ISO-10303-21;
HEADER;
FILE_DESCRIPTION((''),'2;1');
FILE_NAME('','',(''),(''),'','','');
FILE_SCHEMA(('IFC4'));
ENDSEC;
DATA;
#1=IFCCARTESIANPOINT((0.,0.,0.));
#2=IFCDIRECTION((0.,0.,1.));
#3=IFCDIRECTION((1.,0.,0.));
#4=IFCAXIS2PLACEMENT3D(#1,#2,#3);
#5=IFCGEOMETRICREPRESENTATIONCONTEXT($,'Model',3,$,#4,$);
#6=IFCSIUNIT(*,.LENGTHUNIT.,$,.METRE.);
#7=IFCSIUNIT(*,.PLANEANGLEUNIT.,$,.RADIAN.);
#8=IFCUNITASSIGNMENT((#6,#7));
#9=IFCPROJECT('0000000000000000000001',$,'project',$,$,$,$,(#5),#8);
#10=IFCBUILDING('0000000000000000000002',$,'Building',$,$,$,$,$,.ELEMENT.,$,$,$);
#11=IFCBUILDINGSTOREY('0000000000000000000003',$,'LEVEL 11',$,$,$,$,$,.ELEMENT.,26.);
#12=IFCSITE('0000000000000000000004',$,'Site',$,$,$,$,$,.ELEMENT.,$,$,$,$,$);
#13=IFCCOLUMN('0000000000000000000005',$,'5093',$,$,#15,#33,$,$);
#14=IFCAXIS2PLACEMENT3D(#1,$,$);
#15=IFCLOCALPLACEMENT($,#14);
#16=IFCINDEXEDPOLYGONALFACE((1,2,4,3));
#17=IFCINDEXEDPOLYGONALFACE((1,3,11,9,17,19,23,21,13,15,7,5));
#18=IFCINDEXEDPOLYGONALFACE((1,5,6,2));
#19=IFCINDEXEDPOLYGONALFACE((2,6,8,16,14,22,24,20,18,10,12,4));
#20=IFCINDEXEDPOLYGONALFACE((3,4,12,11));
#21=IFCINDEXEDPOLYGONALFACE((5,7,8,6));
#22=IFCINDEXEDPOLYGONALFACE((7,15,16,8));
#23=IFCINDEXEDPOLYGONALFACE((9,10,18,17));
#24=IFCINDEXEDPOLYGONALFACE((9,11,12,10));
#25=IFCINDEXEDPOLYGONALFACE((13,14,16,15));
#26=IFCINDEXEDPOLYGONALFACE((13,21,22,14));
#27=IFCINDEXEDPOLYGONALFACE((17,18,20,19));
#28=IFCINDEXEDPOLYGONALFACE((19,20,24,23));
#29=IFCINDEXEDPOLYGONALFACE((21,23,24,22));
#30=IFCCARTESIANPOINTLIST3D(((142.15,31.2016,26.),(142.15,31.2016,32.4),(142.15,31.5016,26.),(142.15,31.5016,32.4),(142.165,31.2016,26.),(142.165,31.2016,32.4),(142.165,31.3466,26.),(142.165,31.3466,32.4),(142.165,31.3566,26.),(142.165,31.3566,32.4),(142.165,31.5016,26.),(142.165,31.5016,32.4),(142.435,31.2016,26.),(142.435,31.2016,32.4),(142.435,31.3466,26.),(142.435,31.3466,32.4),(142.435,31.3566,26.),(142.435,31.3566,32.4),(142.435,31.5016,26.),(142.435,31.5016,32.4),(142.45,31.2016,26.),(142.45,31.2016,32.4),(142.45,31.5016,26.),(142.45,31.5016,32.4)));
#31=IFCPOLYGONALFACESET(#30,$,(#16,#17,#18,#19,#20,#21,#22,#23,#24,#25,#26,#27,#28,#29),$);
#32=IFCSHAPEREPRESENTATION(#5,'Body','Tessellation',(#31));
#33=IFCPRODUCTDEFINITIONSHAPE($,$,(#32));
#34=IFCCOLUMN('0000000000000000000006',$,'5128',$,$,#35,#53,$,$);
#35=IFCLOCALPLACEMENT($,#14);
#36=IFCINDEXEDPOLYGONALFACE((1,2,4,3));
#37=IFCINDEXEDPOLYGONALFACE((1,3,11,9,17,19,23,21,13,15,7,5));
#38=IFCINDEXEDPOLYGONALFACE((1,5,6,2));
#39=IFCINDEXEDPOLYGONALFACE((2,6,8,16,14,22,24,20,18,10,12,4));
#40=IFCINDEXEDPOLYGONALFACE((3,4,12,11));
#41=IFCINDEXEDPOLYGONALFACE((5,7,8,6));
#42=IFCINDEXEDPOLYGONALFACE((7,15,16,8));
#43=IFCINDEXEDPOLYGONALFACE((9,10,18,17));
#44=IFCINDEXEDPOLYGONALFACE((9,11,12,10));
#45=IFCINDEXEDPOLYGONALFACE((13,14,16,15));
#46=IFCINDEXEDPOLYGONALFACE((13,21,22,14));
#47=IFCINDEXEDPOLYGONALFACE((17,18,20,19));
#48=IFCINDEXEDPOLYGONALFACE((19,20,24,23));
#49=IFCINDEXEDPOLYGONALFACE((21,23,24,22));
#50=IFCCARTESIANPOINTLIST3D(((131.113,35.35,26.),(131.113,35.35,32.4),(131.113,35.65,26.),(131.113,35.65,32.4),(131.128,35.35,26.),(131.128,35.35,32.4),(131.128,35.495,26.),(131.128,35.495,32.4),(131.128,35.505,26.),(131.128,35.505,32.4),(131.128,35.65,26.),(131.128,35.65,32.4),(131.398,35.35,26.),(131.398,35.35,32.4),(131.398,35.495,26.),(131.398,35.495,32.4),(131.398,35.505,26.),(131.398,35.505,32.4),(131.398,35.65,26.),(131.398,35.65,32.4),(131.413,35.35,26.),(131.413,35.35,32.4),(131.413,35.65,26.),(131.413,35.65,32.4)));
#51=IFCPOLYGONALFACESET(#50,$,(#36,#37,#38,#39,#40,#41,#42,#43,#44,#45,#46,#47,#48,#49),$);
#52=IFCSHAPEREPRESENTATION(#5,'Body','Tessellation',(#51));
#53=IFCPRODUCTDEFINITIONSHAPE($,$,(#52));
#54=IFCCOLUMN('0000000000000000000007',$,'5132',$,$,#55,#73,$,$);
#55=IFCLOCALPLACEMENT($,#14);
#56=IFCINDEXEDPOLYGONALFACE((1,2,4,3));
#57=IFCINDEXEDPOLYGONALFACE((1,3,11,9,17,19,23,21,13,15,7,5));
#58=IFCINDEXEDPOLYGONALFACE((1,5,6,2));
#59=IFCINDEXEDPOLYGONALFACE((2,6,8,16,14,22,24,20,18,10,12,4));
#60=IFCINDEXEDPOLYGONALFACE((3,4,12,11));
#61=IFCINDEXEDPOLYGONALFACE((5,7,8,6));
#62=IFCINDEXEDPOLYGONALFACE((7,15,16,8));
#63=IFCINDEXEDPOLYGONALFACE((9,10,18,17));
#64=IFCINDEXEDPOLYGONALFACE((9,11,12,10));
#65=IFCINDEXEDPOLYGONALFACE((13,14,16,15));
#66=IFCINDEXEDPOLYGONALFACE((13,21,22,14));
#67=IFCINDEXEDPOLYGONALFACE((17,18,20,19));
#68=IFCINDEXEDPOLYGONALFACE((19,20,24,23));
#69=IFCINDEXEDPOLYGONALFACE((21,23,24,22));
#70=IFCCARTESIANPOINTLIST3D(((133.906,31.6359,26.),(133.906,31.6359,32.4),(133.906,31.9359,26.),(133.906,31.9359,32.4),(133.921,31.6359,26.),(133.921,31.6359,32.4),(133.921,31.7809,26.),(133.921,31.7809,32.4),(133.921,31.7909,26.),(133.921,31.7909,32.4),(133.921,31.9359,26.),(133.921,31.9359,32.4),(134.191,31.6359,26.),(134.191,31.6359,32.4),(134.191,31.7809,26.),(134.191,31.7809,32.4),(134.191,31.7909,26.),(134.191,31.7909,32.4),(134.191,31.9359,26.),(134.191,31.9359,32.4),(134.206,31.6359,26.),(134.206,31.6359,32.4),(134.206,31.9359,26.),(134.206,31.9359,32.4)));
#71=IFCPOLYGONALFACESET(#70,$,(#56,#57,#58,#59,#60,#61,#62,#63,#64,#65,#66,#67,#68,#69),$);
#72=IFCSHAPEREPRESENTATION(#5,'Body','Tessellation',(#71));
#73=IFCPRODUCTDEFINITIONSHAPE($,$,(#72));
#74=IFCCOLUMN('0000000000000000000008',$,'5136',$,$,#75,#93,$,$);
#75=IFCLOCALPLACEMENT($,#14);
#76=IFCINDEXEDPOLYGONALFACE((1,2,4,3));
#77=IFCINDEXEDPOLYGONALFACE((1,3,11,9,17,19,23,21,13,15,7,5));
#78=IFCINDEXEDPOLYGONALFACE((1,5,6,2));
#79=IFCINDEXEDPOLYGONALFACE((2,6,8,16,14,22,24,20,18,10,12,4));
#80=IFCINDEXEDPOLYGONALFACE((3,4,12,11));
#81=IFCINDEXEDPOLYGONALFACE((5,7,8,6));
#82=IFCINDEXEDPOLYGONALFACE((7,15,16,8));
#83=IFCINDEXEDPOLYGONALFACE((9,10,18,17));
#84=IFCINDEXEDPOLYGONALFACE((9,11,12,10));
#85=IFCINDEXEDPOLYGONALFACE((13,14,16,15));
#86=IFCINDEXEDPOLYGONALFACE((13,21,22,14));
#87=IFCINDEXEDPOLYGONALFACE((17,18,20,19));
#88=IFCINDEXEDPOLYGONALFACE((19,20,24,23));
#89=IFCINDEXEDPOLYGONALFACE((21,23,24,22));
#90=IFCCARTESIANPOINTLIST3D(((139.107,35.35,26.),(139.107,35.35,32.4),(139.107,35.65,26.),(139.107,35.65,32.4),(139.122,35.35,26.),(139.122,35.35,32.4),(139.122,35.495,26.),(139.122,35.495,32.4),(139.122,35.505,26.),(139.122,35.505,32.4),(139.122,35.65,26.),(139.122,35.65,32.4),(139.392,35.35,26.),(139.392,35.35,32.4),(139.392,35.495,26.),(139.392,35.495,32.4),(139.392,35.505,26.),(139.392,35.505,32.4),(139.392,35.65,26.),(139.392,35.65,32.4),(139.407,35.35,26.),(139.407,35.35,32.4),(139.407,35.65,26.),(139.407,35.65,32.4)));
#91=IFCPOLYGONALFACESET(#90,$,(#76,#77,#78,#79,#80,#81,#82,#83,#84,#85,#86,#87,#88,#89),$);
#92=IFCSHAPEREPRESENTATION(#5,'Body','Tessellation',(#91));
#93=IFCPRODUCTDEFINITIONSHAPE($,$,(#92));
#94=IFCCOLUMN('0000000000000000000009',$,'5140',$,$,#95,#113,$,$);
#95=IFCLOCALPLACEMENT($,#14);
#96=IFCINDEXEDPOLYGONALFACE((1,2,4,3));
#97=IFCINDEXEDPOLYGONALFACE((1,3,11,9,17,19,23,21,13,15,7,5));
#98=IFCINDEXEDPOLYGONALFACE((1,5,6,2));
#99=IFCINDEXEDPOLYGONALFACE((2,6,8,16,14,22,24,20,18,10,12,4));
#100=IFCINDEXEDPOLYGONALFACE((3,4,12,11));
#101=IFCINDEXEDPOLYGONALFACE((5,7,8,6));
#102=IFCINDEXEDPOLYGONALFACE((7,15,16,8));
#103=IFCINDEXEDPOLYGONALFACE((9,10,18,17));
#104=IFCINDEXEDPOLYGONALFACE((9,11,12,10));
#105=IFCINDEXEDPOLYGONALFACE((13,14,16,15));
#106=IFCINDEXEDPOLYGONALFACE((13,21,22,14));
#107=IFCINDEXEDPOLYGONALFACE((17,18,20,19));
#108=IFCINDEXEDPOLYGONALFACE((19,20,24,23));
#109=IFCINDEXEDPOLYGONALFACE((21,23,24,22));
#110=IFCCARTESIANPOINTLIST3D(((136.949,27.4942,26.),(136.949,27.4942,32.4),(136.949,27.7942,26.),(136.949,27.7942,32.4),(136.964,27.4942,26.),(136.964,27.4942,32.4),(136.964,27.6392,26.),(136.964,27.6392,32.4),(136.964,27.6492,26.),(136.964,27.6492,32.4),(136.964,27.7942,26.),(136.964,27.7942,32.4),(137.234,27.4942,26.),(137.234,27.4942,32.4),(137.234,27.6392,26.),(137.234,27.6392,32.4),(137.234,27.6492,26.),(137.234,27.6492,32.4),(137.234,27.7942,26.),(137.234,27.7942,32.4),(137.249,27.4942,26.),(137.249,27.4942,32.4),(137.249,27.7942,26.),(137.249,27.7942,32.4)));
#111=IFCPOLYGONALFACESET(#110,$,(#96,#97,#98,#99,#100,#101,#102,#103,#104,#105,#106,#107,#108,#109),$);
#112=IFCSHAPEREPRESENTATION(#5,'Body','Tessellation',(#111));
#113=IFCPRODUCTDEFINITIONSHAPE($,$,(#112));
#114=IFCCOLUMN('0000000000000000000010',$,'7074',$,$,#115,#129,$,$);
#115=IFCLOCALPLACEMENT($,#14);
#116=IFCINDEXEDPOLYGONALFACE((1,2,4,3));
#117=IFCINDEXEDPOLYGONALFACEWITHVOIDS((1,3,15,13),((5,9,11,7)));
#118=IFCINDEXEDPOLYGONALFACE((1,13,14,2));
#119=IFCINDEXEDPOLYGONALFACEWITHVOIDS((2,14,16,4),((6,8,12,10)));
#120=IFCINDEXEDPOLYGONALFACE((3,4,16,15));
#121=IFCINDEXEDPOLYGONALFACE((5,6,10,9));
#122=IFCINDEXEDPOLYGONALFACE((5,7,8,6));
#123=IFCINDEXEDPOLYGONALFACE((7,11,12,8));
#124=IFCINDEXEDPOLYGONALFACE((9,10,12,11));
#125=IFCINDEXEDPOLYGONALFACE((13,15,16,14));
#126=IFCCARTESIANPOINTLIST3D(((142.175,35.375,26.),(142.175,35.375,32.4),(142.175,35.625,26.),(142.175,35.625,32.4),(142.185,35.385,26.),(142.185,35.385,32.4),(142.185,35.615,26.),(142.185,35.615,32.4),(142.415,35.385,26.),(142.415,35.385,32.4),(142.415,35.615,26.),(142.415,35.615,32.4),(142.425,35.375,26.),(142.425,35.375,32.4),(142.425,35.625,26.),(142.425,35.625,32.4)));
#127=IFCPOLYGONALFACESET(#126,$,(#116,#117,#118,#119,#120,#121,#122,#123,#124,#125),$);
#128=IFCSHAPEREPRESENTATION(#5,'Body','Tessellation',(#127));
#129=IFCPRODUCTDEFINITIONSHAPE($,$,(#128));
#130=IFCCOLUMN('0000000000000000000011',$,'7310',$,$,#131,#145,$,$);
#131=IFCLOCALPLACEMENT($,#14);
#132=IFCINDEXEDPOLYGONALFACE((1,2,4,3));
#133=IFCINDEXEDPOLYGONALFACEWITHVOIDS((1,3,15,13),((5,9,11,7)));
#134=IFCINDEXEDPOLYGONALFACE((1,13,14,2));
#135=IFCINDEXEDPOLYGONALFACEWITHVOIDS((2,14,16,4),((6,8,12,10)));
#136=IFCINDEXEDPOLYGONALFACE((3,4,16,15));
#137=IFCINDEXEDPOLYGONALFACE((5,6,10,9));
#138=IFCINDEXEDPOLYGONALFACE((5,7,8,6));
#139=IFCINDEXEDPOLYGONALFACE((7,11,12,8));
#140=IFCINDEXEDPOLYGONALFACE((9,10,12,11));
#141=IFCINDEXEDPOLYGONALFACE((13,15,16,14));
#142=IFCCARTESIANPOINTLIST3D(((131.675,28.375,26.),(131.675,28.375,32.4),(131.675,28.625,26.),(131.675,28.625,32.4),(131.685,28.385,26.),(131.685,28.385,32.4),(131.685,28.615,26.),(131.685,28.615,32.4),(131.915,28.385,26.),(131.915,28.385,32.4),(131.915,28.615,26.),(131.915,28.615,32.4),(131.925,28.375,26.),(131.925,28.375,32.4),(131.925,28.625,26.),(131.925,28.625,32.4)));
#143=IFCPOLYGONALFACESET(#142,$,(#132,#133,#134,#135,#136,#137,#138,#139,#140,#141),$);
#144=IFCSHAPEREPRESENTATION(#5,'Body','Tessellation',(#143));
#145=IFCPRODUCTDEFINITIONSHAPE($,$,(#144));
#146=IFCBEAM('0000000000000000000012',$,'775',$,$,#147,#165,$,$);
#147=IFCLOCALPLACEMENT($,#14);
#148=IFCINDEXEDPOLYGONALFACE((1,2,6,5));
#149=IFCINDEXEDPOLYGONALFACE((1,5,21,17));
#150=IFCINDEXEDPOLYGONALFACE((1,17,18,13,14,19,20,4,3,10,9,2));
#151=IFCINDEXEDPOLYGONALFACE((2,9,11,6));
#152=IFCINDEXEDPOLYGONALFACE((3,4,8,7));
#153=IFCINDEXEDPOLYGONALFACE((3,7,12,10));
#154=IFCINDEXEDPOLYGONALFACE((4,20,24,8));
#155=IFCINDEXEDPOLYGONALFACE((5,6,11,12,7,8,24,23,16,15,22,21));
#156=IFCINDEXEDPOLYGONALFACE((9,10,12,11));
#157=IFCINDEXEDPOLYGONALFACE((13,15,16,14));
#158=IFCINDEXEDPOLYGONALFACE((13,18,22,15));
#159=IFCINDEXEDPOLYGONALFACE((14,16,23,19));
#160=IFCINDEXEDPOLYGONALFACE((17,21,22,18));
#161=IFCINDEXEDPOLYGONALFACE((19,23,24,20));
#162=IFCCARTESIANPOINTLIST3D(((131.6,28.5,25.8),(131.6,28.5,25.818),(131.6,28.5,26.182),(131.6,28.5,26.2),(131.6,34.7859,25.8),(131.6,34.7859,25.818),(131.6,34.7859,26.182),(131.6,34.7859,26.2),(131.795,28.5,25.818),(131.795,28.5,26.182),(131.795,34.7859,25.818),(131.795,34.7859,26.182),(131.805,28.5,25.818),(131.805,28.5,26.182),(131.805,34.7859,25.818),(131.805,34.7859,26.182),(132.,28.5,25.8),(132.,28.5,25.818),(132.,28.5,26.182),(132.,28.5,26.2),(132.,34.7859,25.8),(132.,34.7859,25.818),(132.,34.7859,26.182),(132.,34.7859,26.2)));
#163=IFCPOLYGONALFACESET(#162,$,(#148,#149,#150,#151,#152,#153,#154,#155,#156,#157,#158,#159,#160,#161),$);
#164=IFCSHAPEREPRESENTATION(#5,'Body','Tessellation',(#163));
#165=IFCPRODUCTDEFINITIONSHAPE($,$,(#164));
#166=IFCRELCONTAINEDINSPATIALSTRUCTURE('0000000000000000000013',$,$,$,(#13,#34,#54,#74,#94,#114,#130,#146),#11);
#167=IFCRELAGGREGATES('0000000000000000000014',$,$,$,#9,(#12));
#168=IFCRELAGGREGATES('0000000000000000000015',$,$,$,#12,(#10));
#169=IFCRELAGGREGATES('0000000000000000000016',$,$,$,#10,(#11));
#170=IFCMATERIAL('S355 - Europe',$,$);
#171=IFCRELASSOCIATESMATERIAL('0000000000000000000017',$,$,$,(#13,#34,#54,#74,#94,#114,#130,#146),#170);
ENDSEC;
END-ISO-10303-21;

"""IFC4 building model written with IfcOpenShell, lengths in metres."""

from ifc_helpers import new_model, si_unit, frame, origin_with_axes, origin_2d_with_axis, place, context, project, spatial, hollow_rectangle, i_section, extrude, material, material_profile, profile_set, profile_usage, element, save


model = new_model("IFC4")

# Units and contexts
model_context = context("Model", 3, world=origin_with_axes())
ifc_project = project(units=[si_unit("LENGTHUNIT", "METRE"), si_unit("PLANEANGLEUNIT", "RADIAN")], contexts=[model_context])

# Site, building, storey
site = spatial("IfcSite", under=ifc_project, Name="Site", CompositionType="ELEMENT")
building = spatial("IfcBuilding", under=site, Name="Building", CompositionType="ELEMENT")
storey = spatial("IfcBuildingStorey", under=building, Name="LEVEL 11", CompositionType="ELEMENT", Elevation=26.0)

# Columns
ifc_material = material(Name="S355 - Europe")
ifc_material_profile_1 = material_profile(ifc_material, i_section(OverallWidth=0.3, OverallDepth=0.3, WebThickness=0.01, FlangeThickness=0.015, at=origin_2d_with_axis()))
ifc_profile_set_1 = profile_set([ifc_material_profile_1])
ifc_profile_usage_1 = profile_usage(ifc_profile_set_1, cardinal=10)
column_1_placement = place(None, frame((142.3, 31.3516, 26.0), z_axis=(0.0, 0.0, 1.0), x_axis=(0.0, -1.0, 0.0)))
element("IfcColumn", 1, at=column_1_placement, inside=storey, material=ifc_profile_usage_1, Name="5093", context=model_context, shape_type="SweptSolid", body=[
    extrude(i_section(OverallWidth=0.3, OverallDepth=0.3, WebThickness=0.01, FlangeThickness=0.015, at=origin_2d_with_axis()), origin_with_axes(), (0.0, 0.0, 1.0), 6.4),
])
ifc_material_profile_2 = material_profile(ifc_material, i_section(OverallWidth=0.3, OverallDepth=0.3, WebThickness=0.01, FlangeThickness=0.015, at=origin_2d_with_axis()))
ifc_profile_set_2 = profile_set([ifc_material_profile_2])
ifc_profile_usage_2 = profile_usage(ifc_profile_set_2, cardinal=10)
column_2_placement = place(None, frame((131.263, 35.5, 26.0), z_axis=(0.0, 0.0, 1.0), x_axis=(0.0, -1.0, 0.0)))
element("IfcColumn", 2, at=column_2_placement, inside=storey, material=ifc_profile_usage_2, Name="5128", context=model_context, shape_type="SweptSolid", body=[
    extrude(i_section(OverallWidth=0.3, OverallDepth=0.3, WebThickness=0.01, FlangeThickness=0.015, at=origin_2d_with_axis()), origin_with_axes(), (0.0, 0.0, 1.0), 6.4),
])
ifc_material_profile_3 = material_profile(ifc_material, i_section(OverallWidth=0.3, OverallDepth=0.3, WebThickness=0.01, FlangeThickness=0.015, at=origin_2d_with_axis()))
ifc_profile_set_3 = profile_set([ifc_material_profile_3])
ifc_profile_usage_3 = profile_usage(ifc_profile_set_3, cardinal=10)
column_3_placement = place(None, frame((134.056, 31.7859, 26.0), z_axis=(0.0, 0.0, 1.0), x_axis=(0.0, -1.0, 0.0)))
element("IfcColumn", 3, at=column_3_placement, inside=storey, material=ifc_profile_usage_3, Name="5132", context=model_context, shape_type="SweptSolid", body=[
    extrude(i_section(OverallWidth=0.3, OverallDepth=0.3, WebThickness=0.01, FlangeThickness=0.015, at=origin_2d_with_axis()), origin_with_axes(), (0.0, 0.0, 1.0), 6.4),
])
ifc_material_profile_4 = material_profile(ifc_material, i_section(OverallWidth=0.3, OverallDepth=0.3, WebThickness=0.01, FlangeThickness=0.015, at=origin_2d_with_axis()))
ifc_profile_set_4 = profile_set([ifc_material_profile_4])
ifc_profile_usage_4 = profile_usage(ifc_profile_set_4, cardinal=10)
column_4_placement = place(None, frame((139.257, 35.5, 26.0), z_axis=(0.0, 0.0, 1.0), x_axis=(0.0, -1.0, 0.0)))
element("IfcColumn", 4, at=column_4_placement, inside=storey, material=ifc_profile_usage_4, Name="5136", context=model_context, shape_type="SweptSolid", body=[
    extrude(i_section(OverallWidth=0.3, OverallDepth=0.3, WebThickness=0.01, FlangeThickness=0.015, at=origin_2d_with_axis()), origin_with_axes(), (0.0, 0.0, 1.0), 6.4),
])
ifc_material_profile_5 = material_profile(ifc_material, i_section(OverallWidth=0.3, OverallDepth=0.3, WebThickness=0.01, FlangeThickness=0.015, at=origin_2d_with_axis()))
ifc_profile_set_5 = profile_set([ifc_material_profile_5])
ifc_profile_usage_5 = profile_usage(ifc_profile_set_5, cardinal=10)
column_5_placement = place(None, frame((137.099, 27.6442, 26.0), z_axis=(0.0, 0.0, 1.0), x_axis=(0.0, -1.0, 0.0)))
element("IfcColumn", 5, at=column_5_placement, inside=storey, material=ifc_profile_usage_5, Name="5140", context=model_context, shape_type="SweptSolid", body=[
    extrude(i_section(OverallWidth=0.3, OverallDepth=0.3, WebThickness=0.01, FlangeThickness=0.015, at=origin_2d_with_axis()), origin_with_axes(), (0.0, 0.0, 1.0), 6.4),
])
ifc_material_profile_6 = material_profile(ifc_material, hollow_rectangle(XDim=0.25, YDim=0.25, WallThickness=0.01, at=origin_2d_with_axis()))
ifc_profile_set_6 = profile_set([ifc_material_profile_6])
ifc_profile_usage_6 = profile_usage(ifc_profile_set_6, cardinal=10)
column_6_placement = place(None, frame((142.3, 35.5, 26.0), z_axis=(0.0, 0.0, 1.0), x_axis=(0.0, -1.0, 0.0)))
element("IfcColumn", 6, at=column_6_placement, inside=storey, material=ifc_profile_usage_6, Name="7074", context=model_context, shape_type="SweptSolid", body=[
    extrude(hollow_rectangle(XDim=0.25, YDim=0.25, WallThickness=0.01, at=origin_2d_with_axis()), origin_with_axes(), (0.0, 0.0, 1.0), 6.4),
])
ifc_material_profile_7 = material_profile(ifc_material, hollow_rectangle(XDim=0.25, YDim=0.25, WallThickness=0.01, at=origin_2d_with_axis()))
ifc_profile_set_7 = profile_set([ifc_material_profile_7])
ifc_profile_usage_7 = profile_usage(ifc_profile_set_7, cardinal=10)
column_7_placement = place(None, frame((131.8, 28.5, 26.0), z_axis=(0.0, 0.0, 1.0), x_axis=(0.0, -1.0, 0.0)))
element("IfcColumn", 7, at=column_7_placement, inside=storey, material=ifc_profile_usage_7, Name="7310", context=model_context, shape_type="SweptSolid", body=[
    extrude(hollow_rectangle(XDim=0.25, YDim=0.25, WallThickness=0.01, at=origin_2d_with_axis()), origin_with_axes(), (0.0, 0.0, 1.0), 6.4),
])

# Beam
ifc_material_profile_8 = material_profile(ifc_material, i_section(OverallWidth=0.4, OverallDepth=0.4, WebThickness=0.01, FlangeThickness=0.018, at=origin_2d_with_axis()))
ifc_profile_set_8 = profile_set([ifc_material_profile_8])
ifc_profile_usage_8 = profile_usage(ifc_profile_set_8, cardinal=10)
beam_1_placement = place(None, frame((131.8, 28.5, 26.0), z_axis=(0.0, 1.0, 0.0), x_axis=(-1.0, 0.0, 0.0)))
element("IfcBeam", 8, at=beam_1_placement, inside=storey, material=ifc_profile_usage_8, Name="775", context=model_context, shape_type="SweptSolid", body=[
    extrude(i_section(OverallWidth=0.4, OverallDepth=0.4, WebThickness=0.01, FlangeThickness=0.018, at=origin_2d_with_axis()), origin_with_axes(), (0.0, 0.0, 1.0), 6.2859),
])

save(model, "model.ifc")
